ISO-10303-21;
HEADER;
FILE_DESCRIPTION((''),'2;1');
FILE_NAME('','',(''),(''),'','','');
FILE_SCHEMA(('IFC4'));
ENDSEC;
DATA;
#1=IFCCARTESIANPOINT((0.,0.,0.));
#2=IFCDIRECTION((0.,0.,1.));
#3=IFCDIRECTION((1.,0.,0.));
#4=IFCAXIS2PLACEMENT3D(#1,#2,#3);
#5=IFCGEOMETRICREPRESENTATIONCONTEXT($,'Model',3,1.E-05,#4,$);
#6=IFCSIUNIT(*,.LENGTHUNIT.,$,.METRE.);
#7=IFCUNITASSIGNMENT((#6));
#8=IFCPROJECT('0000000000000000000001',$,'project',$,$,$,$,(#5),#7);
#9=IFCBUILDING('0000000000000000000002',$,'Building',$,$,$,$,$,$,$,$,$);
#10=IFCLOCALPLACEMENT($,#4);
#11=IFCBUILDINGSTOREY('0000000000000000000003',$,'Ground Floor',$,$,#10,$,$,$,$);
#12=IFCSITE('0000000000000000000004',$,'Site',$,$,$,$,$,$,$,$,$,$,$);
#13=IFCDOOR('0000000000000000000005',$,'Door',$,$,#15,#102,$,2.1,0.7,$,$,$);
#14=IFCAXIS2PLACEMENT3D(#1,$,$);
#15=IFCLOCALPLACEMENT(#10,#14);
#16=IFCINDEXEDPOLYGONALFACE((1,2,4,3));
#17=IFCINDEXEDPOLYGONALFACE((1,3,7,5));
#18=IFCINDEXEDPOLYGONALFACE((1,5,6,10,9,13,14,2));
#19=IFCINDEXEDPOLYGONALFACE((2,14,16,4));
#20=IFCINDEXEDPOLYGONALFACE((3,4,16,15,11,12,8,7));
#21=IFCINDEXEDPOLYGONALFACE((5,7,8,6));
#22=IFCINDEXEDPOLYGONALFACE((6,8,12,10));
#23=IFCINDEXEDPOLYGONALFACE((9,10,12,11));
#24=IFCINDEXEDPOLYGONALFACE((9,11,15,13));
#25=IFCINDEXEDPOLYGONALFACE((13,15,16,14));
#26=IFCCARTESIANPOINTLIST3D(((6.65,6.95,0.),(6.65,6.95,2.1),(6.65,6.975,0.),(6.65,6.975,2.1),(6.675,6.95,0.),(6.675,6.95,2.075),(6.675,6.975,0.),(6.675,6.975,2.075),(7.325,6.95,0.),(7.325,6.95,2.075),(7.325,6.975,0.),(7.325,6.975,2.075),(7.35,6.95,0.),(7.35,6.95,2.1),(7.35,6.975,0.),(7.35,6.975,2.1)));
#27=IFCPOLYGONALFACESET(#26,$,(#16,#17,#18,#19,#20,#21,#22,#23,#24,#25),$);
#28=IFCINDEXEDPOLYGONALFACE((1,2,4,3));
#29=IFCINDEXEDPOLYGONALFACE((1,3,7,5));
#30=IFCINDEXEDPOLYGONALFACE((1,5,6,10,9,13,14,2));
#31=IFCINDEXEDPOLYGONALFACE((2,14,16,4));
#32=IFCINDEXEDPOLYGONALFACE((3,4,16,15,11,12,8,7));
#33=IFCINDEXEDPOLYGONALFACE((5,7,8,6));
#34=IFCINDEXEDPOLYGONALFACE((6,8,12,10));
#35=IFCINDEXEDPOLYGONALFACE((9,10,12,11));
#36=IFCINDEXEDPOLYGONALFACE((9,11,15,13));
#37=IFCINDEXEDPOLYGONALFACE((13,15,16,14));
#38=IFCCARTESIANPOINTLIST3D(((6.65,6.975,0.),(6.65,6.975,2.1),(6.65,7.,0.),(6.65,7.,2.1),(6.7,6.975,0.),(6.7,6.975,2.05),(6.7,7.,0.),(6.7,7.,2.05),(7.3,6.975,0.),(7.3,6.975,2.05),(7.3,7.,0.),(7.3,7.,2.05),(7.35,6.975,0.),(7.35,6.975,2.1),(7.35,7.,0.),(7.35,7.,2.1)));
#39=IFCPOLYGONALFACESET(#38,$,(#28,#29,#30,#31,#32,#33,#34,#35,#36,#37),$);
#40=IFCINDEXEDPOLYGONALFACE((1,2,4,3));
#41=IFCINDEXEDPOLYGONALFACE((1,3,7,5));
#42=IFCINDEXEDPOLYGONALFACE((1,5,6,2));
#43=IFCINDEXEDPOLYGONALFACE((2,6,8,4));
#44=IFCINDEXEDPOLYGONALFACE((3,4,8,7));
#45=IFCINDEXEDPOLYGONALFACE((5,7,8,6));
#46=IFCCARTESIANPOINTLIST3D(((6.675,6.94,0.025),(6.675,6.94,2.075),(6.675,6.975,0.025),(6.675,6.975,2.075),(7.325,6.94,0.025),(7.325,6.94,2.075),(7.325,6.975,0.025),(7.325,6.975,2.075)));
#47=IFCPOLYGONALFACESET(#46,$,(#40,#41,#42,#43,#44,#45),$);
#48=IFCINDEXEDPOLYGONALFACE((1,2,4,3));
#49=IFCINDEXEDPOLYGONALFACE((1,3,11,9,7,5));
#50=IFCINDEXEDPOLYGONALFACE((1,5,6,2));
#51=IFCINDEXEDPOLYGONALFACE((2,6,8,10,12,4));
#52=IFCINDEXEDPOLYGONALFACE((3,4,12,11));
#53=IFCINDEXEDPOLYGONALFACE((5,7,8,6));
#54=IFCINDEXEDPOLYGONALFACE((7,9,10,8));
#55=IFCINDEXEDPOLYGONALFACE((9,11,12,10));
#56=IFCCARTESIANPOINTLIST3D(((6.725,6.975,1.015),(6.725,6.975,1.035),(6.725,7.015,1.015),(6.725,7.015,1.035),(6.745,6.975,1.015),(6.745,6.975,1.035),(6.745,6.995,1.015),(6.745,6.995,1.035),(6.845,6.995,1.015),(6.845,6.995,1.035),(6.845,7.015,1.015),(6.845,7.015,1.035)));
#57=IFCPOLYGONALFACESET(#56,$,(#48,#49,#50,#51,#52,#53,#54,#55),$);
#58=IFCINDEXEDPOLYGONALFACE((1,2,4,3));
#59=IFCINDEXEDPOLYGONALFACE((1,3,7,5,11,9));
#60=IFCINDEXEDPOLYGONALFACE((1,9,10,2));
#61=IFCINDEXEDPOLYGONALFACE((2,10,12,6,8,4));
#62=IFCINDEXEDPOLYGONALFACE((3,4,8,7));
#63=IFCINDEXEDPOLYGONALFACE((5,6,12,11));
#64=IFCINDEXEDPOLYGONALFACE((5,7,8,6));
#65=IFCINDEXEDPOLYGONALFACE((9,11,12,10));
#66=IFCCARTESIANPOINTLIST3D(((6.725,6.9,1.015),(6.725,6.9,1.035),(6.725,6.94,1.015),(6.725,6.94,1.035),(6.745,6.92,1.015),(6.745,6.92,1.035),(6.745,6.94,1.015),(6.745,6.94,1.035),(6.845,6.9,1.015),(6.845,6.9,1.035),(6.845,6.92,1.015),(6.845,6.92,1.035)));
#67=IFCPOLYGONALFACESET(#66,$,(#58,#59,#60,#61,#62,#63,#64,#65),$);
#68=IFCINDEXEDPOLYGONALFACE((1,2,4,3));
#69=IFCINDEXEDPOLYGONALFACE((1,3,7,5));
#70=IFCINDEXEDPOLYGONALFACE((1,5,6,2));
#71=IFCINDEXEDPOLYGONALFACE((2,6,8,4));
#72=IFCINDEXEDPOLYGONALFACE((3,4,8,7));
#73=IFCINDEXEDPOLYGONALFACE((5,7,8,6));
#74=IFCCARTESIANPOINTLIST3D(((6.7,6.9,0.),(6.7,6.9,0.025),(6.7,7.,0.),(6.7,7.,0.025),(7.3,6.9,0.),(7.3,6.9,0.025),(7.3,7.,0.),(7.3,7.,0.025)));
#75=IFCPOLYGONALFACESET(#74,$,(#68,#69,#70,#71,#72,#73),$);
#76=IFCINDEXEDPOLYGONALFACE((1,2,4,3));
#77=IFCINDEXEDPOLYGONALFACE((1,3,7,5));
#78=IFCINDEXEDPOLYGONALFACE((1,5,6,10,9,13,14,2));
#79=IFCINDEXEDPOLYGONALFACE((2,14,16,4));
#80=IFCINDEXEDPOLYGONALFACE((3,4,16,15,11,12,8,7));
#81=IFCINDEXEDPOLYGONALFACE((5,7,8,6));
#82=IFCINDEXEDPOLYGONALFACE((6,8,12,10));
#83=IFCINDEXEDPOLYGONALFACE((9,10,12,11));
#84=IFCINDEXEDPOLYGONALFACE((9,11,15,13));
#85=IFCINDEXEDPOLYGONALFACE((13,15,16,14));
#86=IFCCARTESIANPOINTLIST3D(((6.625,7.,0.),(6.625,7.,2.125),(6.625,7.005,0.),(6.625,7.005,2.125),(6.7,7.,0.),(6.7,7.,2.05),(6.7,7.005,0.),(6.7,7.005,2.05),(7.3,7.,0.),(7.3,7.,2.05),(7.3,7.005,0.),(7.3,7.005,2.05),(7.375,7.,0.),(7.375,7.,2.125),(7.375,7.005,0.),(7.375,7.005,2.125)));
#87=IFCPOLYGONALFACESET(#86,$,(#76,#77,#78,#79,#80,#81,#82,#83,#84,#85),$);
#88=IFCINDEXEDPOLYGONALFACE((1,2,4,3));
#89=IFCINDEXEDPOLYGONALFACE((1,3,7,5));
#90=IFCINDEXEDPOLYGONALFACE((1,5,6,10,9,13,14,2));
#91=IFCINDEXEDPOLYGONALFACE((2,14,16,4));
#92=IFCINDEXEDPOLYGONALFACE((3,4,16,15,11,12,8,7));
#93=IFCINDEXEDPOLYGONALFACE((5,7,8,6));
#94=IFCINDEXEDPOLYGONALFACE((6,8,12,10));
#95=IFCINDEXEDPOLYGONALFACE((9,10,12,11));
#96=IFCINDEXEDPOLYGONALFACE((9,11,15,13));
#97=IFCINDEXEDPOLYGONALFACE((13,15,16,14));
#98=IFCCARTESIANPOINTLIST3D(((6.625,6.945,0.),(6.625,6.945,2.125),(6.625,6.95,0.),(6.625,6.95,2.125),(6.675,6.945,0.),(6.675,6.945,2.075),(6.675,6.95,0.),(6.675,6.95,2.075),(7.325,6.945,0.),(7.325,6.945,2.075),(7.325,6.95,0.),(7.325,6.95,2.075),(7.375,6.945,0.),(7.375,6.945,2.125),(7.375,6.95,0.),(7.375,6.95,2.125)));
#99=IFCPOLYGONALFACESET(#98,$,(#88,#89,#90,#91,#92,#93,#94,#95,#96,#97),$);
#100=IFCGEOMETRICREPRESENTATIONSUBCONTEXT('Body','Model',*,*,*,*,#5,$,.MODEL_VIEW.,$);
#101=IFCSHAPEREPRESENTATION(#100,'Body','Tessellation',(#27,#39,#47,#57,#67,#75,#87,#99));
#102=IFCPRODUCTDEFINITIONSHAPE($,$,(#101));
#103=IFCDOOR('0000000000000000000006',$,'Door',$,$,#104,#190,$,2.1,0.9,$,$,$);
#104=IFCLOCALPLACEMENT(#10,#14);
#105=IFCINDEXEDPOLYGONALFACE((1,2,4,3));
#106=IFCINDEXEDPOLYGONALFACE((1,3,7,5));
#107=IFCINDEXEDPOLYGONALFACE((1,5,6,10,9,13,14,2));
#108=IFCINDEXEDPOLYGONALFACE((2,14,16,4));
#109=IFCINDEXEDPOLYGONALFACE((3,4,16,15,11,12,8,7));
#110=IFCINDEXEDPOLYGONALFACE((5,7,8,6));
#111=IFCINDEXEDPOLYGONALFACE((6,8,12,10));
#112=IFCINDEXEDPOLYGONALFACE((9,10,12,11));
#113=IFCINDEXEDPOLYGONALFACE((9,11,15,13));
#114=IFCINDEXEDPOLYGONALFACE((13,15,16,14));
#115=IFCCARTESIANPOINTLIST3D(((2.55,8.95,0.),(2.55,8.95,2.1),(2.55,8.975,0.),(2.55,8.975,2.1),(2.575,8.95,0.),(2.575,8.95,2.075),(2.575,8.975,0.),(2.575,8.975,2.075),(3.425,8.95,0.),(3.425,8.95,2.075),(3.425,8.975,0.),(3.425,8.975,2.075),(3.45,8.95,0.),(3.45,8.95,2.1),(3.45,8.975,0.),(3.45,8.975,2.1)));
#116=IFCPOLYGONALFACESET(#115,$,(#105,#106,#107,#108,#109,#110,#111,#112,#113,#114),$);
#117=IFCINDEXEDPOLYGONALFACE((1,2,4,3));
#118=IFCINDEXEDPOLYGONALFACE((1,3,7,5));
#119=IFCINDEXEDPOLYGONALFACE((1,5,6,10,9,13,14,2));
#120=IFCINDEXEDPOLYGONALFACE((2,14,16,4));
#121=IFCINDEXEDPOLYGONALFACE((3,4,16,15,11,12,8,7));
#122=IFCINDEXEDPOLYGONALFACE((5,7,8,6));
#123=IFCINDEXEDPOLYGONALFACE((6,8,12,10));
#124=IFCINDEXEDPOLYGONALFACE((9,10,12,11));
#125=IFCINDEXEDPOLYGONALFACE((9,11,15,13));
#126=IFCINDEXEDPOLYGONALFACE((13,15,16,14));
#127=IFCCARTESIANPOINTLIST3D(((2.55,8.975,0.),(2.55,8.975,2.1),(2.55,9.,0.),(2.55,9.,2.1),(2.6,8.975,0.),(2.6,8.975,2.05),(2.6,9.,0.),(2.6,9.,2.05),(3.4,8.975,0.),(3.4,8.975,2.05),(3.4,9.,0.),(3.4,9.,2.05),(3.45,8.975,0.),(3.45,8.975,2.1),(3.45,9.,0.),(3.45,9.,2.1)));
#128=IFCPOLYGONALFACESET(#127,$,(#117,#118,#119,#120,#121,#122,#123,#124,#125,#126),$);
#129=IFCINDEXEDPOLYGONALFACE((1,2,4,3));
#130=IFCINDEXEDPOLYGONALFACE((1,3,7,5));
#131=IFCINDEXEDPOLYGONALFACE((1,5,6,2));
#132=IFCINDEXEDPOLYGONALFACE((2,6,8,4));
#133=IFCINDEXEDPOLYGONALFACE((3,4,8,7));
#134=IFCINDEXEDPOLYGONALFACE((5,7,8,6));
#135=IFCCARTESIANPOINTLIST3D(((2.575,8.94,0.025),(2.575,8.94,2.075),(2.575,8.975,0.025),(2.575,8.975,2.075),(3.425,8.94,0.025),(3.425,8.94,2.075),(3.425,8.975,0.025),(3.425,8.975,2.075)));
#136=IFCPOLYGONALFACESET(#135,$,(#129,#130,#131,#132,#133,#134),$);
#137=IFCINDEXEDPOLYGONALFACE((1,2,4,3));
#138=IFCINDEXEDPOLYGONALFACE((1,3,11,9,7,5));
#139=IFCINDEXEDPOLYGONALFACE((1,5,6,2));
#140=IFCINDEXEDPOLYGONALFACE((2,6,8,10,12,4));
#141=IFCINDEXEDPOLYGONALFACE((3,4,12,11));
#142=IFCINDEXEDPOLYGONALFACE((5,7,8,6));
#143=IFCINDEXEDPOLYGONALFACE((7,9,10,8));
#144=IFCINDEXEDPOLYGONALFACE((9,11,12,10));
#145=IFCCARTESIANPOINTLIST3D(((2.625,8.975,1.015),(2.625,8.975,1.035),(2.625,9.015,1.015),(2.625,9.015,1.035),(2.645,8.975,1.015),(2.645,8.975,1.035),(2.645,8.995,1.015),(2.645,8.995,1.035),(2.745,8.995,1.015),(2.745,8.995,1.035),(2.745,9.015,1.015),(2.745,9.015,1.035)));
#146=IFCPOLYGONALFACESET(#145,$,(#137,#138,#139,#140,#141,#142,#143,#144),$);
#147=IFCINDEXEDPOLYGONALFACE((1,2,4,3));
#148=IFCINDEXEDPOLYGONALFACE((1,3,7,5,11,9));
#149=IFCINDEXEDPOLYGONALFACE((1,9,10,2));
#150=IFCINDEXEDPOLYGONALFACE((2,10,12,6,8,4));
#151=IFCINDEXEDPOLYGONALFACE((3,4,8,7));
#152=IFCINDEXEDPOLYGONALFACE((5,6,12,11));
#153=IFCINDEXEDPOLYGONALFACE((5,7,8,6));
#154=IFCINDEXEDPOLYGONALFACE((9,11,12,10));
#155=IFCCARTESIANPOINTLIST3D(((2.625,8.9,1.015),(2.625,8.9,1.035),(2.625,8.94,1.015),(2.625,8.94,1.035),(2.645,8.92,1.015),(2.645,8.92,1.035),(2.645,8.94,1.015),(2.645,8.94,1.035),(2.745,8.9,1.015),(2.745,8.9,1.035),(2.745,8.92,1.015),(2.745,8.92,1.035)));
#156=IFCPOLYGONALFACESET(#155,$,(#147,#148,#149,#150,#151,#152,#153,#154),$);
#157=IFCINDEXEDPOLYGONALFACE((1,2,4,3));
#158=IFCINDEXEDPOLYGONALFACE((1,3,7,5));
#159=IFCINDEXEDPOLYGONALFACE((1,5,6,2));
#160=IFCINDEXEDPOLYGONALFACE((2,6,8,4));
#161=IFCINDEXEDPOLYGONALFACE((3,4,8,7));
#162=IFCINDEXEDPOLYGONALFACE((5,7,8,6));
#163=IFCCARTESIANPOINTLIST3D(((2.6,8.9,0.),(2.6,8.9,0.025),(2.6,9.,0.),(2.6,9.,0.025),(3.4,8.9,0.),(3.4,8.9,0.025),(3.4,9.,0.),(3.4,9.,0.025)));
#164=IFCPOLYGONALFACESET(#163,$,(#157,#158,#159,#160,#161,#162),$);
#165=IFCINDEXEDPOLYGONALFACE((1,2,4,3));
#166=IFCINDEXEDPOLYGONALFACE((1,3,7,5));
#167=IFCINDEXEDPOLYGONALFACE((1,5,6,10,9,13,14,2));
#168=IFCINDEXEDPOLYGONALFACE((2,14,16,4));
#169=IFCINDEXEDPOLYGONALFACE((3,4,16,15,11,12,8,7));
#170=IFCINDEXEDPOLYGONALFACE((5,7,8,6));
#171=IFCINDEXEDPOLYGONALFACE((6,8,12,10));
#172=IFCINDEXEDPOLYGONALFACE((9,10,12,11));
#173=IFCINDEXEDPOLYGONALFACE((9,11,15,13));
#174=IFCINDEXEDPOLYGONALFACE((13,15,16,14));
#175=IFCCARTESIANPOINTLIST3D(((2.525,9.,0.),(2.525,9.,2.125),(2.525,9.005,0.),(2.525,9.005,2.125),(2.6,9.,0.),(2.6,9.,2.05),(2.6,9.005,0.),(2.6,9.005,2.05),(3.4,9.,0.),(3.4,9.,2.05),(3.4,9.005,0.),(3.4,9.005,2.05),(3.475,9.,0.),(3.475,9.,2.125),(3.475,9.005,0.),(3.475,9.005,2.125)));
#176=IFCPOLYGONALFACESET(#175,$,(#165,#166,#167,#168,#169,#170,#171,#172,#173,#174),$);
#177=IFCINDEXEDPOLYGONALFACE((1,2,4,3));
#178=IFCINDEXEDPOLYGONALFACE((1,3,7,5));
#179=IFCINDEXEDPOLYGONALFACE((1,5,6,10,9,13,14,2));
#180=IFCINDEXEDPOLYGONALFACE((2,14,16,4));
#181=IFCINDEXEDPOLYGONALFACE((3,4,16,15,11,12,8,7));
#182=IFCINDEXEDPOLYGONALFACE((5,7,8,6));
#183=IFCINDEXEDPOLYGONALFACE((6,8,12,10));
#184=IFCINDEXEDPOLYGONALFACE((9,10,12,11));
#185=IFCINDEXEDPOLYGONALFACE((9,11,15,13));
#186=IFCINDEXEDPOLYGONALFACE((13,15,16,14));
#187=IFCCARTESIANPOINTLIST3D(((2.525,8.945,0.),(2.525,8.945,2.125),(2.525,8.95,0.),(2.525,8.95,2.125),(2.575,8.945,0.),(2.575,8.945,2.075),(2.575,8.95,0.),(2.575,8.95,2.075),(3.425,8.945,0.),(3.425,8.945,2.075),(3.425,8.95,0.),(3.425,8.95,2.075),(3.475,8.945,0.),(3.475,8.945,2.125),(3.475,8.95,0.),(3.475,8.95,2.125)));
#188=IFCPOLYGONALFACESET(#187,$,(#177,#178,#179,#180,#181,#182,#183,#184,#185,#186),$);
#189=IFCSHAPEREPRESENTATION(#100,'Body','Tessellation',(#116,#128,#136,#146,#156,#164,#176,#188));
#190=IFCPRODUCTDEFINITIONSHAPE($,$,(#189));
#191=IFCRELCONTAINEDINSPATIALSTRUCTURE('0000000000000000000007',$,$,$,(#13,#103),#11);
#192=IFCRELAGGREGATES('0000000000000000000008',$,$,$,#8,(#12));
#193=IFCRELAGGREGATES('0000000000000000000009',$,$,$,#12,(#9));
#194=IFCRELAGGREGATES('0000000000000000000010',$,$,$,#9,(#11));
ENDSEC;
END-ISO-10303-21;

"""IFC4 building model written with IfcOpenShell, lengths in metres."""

from ifc_helpers import new_model, si_unit, frame, origin_with_axes, place, context, subcontext, project, spatial, line, indexed_curve, outline, extrude, element, save


model = new_model("IFC4")

# Units and contexts
model_context = context("Model", 3, precision=1e-05, world=origin_with_axes())
body_context = subcontext(model_context, "Body", "Model", "MODEL_VIEW")
ifc_project = project(units=[si_unit("LENGTHUNIT", "METRE")], contexts=[model_context])

# Site, building, storey
site = spatial("IfcSite", under=ifc_project, Name="Site")
building = spatial("IfcBuilding", under=site, Name="Building")
storey_placement = place(None, origin_with_axes())
storey = spatial("IfcBuildingStorey", under=building, at=storey_placement, Name="Ground Floor")

# Doors
door_1_placement = place(storey_placement, frame((7.35, 7.0, 0.0), z_axis=(0.0, 0.0, 1.0), x_axis=(-1.0, 0.0, 0.0)))
element("IfcDoor", 1, at=door_1_placement, inside=storey, Name="Door", OverallHeight=2.1, OverallWidth=0.7, context=body_context, shape_type="SweptSolid", body=[
    extrude(outline(indexed_curve([(0.0, 0.0), (0.0, 2.1), (0.7, 2.1), (0.7, 0.0), (0.675, 0.0), (0.675, 2.075), (0.025, 2.075), (0.025, 0.0)], segments=[line(1, 2, 3, 4, 5, 6, 7, 8, 1)])), frame((0.0, 0.025, 0.0), z_axis=(0.0, -1.0, 0.0), x_axis=(1.0, 0.0, 0.0)), (0.0, 0.0, -1.0), 0.025),
    extrude(outline(indexed_curve([(0.0, 0.0), (0.0, 2.1), (0.7, 2.1), (0.7, 0.0), (0.65, 0.0), (0.65, 2.05), (0.05, 2.05), (0.05, 0.0)], segments=[line(1, 2, 3, 4, 5, 6, 7, 8, 1)])), frame((0.0, 0.0, 0.0), z_axis=(0.0, -1.0, 0.0), x_axis=(1.0, 0.0, 0.0)), (0.0, 0.0, -1.0), 0.025),
    extrude(outline(indexed_curve([(0.0, 0.0), (0.65, 0.0), (0.65, 0.035), (0.0, 0.035)], segments=[line(1, 2, 3, 4, 1)])), frame((0.025, 0.025, 0.025), z_axis=(0.0, 0.0, 1.0), x_axis=(1.0, 0.0, 0.0)), (0.0, 0.0, 1.0), 2.05),
    extrude(outline(indexed_curve([(0.0, 0.0), (0.0, -0.04), (-0.12, -0.04), (-0.12, -0.02), (-0.02, -0.02), (-0.02, 0.0)], segments=[line(1, 2, 3, 4, 5, 6, 1)])), frame((0.625, 0.025, 1.015), z_axis=(0.0, 0.0, 1.0), x_axis=(1.0, 0.0, 0.0)), (0.0, 0.0, 1.0), 0.02),
    extrude(outline(indexed_curve([(0.0, 0.0), (0.0, 0.04), (-0.12, 0.04), (-0.12, 0.02), (-0.02, 0.02), (-0.02, 0.0)], segments=[line(1, 2, 3, 4, 5, 6, 1)])), frame((0.625, 0.06, 1.015), z_axis=(0.0, 0.0, 1.0), x_axis=(1.0, 0.0, 0.0)), (0.0, 0.0, 1.0), 0.02),
    extrude(outline(indexed_curve([(0.0, 0.0), (0.6, 0.0), (0.6, 0.1), (0.0, 0.1)], segments=[line(1, 2, 3, 4, 1)])), frame((0.05, 0.0, 0.0), z_axis=(0.0, 0.0, 1.0), x_axis=(1.0, 0.0, 0.0)), (0.0, 0.0, 1.0), 0.025),
    extrude(outline(indexed_curve([(0.0, 0.0), (0.0, 2.125), (0.75, 2.125), (0.75, 0.0), (0.675, 0.0), (0.675, 2.05), (0.075, 2.05), (0.075, 0.0)], segments=[line(1, 2, 3, 4, 5, 6, 7, 8, 1)])), frame((-0.025, -0.005, 0.0), z_axis=(0.0, -1.0, 0.0), x_axis=(1.0, 0.0, 0.0)), (0.0, 0.0, -1.0), 0.005),
    extrude(outline(indexed_curve([(0.0, 0.0), (0.0, 2.125), (0.75, 2.125), (0.75, 0.0), (0.7, 0.0), (0.7, 2.075), (0.05, 2.075), (0.05, 0.0)], segments=[line(1, 2, 3, 4, 5, 6, 7, 8, 1)])), frame((-0.025, 0.05, 0.0), z_axis=(0.0, -1.0, 0.0), x_axis=(1.0, 0.0, 0.0)), (0.0, 0.0, -1.0), 0.005),
])
door_2_placement = place(storey_placement, frame((3.45, 9.0, 0.0), z_axis=(0.0, 0.0, 1.0), x_axis=(-1.0, 0.0, 0.0)))
element("IfcDoor", 2, at=door_2_placement, inside=storey, Name="Door", OverallHeight=2.1, OverallWidth=0.9, context=body_context, shape_type="SweptSolid", body=[
    extrude(outline(indexed_curve([(0.0, 0.0), (0.0, 2.1), (0.9, 2.1), (0.9, 0.0), (0.875, 0.0), (0.875, 2.075), (0.025, 2.075), (0.025, 0.0)], segments=[line(1, 2, 3, 4, 5, 6, 7, 8, 1)])), frame((0.0, 0.025, 0.0), z_axis=(0.0, -1.0, 0.0), x_axis=(1.0, 0.0, 0.0)), (0.0, 0.0, -1.0), 0.025),
    extrude(outline(indexed_curve([(0.0, 0.0), (0.0, 2.1), (0.9, 2.1), (0.9, 0.0), (0.85, 0.0), (0.85, 2.05), (0.05, 2.05), (0.05, 0.0)], segments=[line(1, 2, 3, 4, 5, 6, 7, 8, 1)])), frame((0.0, 0.0, 0.0), z_axis=(0.0, -1.0, 0.0), x_axis=(1.0, 0.0, 0.0)), (0.0, 0.0, -1.0), 0.025),
    extrude(outline(indexed_curve([(0.0, 0.0), (0.85, 0.0), (0.85, 0.035), (0.0, 0.035)], segments=[line(1, 2, 3, 4, 1)])), frame((0.025, 0.025, 0.025), z_axis=(0.0, 0.0, 1.0), x_axis=(1.0, 0.0, 0.0)), (0.0, 0.0, 1.0), 2.05),
    extrude(outline(indexed_curve([(0.0, 0.0), (0.0, -0.04), (-0.12, -0.04), (-0.12, -0.02), (-0.02, -0.02), (-0.02, 0.0)], segments=[line(1, 2, 3, 4, 5, 6, 1)])), frame((0.825, 0.025, 1.015), z_axis=(0.0, 0.0, 1.0), x_axis=(1.0, 0.0, 0.0)), (0.0, 0.0, 1.0), 0.02),
    extrude(outline(indexed_curve([(0.0, 0.0), (0.0, 0.04), (-0.12, 0.04), (-0.12, 0.02), (-0.02, 0.02), (-0.02, 0.0)], segments=[line(1, 2, 3, 4, 5, 6, 1)])), frame((0.825, 0.06, 1.015), z_axis=(0.0, 0.0, 1.0), x_axis=(1.0, 0.0, 0.0)), (0.0, 0.0, 1.0), 0.02),
    extrude(outline(indexed_curve([(0.0, 0.0), (0.8, 0.0), (0.8, 0.1), (0.0, 0.1)], segments=[line(1, 2, 3, 4, 1)])), frame((0.05, 0.0, 0.0), z_axis=(0.0, 0.0, 1.0), x_axis=(1.0, 0.0, 0.0)), (0.0, 0.0, 1.0), 0.025),
    extrude(outline(indexed_curve([(0.0, 0.0), (0.0, 2.125), (0.95, 2.125), (0.95, 0.0), (0.875, 0.0), (0.875, 2.05), (0.075, 2.05), (0.075, 0.0)], segments=[line(1, 2, 3, 4, 5, 6, 7, 8, 1)])), frame((-0.025, -0.005, 0.0), z_axis=(0.0, -1.0, 0.0), x_axis=(1.0, 0.0, 0.0)), (0.0, 0.0, -1.0), 0.005),
    extrude(outline(indexed_curve([(0.0, 0.0), (0.0, 2.125), (0.95, 2.125), (0.95, 0.0), (0.9, 0.0), (0.9, 2.075), (0.05, 2.075), (0.05, 0.0)], segments=[line(1, 2, 3, 4, 5, 6, 7, 8, 1)])), frame((-0.025, 0.05, 0.0), z_axis=(0.0, -1.0, 0.0), x_axis=(1.0, 0.0, 0.0)), (0.0, 0.0, -1.0), 0.005),
])

save(model, "model.ifc")
